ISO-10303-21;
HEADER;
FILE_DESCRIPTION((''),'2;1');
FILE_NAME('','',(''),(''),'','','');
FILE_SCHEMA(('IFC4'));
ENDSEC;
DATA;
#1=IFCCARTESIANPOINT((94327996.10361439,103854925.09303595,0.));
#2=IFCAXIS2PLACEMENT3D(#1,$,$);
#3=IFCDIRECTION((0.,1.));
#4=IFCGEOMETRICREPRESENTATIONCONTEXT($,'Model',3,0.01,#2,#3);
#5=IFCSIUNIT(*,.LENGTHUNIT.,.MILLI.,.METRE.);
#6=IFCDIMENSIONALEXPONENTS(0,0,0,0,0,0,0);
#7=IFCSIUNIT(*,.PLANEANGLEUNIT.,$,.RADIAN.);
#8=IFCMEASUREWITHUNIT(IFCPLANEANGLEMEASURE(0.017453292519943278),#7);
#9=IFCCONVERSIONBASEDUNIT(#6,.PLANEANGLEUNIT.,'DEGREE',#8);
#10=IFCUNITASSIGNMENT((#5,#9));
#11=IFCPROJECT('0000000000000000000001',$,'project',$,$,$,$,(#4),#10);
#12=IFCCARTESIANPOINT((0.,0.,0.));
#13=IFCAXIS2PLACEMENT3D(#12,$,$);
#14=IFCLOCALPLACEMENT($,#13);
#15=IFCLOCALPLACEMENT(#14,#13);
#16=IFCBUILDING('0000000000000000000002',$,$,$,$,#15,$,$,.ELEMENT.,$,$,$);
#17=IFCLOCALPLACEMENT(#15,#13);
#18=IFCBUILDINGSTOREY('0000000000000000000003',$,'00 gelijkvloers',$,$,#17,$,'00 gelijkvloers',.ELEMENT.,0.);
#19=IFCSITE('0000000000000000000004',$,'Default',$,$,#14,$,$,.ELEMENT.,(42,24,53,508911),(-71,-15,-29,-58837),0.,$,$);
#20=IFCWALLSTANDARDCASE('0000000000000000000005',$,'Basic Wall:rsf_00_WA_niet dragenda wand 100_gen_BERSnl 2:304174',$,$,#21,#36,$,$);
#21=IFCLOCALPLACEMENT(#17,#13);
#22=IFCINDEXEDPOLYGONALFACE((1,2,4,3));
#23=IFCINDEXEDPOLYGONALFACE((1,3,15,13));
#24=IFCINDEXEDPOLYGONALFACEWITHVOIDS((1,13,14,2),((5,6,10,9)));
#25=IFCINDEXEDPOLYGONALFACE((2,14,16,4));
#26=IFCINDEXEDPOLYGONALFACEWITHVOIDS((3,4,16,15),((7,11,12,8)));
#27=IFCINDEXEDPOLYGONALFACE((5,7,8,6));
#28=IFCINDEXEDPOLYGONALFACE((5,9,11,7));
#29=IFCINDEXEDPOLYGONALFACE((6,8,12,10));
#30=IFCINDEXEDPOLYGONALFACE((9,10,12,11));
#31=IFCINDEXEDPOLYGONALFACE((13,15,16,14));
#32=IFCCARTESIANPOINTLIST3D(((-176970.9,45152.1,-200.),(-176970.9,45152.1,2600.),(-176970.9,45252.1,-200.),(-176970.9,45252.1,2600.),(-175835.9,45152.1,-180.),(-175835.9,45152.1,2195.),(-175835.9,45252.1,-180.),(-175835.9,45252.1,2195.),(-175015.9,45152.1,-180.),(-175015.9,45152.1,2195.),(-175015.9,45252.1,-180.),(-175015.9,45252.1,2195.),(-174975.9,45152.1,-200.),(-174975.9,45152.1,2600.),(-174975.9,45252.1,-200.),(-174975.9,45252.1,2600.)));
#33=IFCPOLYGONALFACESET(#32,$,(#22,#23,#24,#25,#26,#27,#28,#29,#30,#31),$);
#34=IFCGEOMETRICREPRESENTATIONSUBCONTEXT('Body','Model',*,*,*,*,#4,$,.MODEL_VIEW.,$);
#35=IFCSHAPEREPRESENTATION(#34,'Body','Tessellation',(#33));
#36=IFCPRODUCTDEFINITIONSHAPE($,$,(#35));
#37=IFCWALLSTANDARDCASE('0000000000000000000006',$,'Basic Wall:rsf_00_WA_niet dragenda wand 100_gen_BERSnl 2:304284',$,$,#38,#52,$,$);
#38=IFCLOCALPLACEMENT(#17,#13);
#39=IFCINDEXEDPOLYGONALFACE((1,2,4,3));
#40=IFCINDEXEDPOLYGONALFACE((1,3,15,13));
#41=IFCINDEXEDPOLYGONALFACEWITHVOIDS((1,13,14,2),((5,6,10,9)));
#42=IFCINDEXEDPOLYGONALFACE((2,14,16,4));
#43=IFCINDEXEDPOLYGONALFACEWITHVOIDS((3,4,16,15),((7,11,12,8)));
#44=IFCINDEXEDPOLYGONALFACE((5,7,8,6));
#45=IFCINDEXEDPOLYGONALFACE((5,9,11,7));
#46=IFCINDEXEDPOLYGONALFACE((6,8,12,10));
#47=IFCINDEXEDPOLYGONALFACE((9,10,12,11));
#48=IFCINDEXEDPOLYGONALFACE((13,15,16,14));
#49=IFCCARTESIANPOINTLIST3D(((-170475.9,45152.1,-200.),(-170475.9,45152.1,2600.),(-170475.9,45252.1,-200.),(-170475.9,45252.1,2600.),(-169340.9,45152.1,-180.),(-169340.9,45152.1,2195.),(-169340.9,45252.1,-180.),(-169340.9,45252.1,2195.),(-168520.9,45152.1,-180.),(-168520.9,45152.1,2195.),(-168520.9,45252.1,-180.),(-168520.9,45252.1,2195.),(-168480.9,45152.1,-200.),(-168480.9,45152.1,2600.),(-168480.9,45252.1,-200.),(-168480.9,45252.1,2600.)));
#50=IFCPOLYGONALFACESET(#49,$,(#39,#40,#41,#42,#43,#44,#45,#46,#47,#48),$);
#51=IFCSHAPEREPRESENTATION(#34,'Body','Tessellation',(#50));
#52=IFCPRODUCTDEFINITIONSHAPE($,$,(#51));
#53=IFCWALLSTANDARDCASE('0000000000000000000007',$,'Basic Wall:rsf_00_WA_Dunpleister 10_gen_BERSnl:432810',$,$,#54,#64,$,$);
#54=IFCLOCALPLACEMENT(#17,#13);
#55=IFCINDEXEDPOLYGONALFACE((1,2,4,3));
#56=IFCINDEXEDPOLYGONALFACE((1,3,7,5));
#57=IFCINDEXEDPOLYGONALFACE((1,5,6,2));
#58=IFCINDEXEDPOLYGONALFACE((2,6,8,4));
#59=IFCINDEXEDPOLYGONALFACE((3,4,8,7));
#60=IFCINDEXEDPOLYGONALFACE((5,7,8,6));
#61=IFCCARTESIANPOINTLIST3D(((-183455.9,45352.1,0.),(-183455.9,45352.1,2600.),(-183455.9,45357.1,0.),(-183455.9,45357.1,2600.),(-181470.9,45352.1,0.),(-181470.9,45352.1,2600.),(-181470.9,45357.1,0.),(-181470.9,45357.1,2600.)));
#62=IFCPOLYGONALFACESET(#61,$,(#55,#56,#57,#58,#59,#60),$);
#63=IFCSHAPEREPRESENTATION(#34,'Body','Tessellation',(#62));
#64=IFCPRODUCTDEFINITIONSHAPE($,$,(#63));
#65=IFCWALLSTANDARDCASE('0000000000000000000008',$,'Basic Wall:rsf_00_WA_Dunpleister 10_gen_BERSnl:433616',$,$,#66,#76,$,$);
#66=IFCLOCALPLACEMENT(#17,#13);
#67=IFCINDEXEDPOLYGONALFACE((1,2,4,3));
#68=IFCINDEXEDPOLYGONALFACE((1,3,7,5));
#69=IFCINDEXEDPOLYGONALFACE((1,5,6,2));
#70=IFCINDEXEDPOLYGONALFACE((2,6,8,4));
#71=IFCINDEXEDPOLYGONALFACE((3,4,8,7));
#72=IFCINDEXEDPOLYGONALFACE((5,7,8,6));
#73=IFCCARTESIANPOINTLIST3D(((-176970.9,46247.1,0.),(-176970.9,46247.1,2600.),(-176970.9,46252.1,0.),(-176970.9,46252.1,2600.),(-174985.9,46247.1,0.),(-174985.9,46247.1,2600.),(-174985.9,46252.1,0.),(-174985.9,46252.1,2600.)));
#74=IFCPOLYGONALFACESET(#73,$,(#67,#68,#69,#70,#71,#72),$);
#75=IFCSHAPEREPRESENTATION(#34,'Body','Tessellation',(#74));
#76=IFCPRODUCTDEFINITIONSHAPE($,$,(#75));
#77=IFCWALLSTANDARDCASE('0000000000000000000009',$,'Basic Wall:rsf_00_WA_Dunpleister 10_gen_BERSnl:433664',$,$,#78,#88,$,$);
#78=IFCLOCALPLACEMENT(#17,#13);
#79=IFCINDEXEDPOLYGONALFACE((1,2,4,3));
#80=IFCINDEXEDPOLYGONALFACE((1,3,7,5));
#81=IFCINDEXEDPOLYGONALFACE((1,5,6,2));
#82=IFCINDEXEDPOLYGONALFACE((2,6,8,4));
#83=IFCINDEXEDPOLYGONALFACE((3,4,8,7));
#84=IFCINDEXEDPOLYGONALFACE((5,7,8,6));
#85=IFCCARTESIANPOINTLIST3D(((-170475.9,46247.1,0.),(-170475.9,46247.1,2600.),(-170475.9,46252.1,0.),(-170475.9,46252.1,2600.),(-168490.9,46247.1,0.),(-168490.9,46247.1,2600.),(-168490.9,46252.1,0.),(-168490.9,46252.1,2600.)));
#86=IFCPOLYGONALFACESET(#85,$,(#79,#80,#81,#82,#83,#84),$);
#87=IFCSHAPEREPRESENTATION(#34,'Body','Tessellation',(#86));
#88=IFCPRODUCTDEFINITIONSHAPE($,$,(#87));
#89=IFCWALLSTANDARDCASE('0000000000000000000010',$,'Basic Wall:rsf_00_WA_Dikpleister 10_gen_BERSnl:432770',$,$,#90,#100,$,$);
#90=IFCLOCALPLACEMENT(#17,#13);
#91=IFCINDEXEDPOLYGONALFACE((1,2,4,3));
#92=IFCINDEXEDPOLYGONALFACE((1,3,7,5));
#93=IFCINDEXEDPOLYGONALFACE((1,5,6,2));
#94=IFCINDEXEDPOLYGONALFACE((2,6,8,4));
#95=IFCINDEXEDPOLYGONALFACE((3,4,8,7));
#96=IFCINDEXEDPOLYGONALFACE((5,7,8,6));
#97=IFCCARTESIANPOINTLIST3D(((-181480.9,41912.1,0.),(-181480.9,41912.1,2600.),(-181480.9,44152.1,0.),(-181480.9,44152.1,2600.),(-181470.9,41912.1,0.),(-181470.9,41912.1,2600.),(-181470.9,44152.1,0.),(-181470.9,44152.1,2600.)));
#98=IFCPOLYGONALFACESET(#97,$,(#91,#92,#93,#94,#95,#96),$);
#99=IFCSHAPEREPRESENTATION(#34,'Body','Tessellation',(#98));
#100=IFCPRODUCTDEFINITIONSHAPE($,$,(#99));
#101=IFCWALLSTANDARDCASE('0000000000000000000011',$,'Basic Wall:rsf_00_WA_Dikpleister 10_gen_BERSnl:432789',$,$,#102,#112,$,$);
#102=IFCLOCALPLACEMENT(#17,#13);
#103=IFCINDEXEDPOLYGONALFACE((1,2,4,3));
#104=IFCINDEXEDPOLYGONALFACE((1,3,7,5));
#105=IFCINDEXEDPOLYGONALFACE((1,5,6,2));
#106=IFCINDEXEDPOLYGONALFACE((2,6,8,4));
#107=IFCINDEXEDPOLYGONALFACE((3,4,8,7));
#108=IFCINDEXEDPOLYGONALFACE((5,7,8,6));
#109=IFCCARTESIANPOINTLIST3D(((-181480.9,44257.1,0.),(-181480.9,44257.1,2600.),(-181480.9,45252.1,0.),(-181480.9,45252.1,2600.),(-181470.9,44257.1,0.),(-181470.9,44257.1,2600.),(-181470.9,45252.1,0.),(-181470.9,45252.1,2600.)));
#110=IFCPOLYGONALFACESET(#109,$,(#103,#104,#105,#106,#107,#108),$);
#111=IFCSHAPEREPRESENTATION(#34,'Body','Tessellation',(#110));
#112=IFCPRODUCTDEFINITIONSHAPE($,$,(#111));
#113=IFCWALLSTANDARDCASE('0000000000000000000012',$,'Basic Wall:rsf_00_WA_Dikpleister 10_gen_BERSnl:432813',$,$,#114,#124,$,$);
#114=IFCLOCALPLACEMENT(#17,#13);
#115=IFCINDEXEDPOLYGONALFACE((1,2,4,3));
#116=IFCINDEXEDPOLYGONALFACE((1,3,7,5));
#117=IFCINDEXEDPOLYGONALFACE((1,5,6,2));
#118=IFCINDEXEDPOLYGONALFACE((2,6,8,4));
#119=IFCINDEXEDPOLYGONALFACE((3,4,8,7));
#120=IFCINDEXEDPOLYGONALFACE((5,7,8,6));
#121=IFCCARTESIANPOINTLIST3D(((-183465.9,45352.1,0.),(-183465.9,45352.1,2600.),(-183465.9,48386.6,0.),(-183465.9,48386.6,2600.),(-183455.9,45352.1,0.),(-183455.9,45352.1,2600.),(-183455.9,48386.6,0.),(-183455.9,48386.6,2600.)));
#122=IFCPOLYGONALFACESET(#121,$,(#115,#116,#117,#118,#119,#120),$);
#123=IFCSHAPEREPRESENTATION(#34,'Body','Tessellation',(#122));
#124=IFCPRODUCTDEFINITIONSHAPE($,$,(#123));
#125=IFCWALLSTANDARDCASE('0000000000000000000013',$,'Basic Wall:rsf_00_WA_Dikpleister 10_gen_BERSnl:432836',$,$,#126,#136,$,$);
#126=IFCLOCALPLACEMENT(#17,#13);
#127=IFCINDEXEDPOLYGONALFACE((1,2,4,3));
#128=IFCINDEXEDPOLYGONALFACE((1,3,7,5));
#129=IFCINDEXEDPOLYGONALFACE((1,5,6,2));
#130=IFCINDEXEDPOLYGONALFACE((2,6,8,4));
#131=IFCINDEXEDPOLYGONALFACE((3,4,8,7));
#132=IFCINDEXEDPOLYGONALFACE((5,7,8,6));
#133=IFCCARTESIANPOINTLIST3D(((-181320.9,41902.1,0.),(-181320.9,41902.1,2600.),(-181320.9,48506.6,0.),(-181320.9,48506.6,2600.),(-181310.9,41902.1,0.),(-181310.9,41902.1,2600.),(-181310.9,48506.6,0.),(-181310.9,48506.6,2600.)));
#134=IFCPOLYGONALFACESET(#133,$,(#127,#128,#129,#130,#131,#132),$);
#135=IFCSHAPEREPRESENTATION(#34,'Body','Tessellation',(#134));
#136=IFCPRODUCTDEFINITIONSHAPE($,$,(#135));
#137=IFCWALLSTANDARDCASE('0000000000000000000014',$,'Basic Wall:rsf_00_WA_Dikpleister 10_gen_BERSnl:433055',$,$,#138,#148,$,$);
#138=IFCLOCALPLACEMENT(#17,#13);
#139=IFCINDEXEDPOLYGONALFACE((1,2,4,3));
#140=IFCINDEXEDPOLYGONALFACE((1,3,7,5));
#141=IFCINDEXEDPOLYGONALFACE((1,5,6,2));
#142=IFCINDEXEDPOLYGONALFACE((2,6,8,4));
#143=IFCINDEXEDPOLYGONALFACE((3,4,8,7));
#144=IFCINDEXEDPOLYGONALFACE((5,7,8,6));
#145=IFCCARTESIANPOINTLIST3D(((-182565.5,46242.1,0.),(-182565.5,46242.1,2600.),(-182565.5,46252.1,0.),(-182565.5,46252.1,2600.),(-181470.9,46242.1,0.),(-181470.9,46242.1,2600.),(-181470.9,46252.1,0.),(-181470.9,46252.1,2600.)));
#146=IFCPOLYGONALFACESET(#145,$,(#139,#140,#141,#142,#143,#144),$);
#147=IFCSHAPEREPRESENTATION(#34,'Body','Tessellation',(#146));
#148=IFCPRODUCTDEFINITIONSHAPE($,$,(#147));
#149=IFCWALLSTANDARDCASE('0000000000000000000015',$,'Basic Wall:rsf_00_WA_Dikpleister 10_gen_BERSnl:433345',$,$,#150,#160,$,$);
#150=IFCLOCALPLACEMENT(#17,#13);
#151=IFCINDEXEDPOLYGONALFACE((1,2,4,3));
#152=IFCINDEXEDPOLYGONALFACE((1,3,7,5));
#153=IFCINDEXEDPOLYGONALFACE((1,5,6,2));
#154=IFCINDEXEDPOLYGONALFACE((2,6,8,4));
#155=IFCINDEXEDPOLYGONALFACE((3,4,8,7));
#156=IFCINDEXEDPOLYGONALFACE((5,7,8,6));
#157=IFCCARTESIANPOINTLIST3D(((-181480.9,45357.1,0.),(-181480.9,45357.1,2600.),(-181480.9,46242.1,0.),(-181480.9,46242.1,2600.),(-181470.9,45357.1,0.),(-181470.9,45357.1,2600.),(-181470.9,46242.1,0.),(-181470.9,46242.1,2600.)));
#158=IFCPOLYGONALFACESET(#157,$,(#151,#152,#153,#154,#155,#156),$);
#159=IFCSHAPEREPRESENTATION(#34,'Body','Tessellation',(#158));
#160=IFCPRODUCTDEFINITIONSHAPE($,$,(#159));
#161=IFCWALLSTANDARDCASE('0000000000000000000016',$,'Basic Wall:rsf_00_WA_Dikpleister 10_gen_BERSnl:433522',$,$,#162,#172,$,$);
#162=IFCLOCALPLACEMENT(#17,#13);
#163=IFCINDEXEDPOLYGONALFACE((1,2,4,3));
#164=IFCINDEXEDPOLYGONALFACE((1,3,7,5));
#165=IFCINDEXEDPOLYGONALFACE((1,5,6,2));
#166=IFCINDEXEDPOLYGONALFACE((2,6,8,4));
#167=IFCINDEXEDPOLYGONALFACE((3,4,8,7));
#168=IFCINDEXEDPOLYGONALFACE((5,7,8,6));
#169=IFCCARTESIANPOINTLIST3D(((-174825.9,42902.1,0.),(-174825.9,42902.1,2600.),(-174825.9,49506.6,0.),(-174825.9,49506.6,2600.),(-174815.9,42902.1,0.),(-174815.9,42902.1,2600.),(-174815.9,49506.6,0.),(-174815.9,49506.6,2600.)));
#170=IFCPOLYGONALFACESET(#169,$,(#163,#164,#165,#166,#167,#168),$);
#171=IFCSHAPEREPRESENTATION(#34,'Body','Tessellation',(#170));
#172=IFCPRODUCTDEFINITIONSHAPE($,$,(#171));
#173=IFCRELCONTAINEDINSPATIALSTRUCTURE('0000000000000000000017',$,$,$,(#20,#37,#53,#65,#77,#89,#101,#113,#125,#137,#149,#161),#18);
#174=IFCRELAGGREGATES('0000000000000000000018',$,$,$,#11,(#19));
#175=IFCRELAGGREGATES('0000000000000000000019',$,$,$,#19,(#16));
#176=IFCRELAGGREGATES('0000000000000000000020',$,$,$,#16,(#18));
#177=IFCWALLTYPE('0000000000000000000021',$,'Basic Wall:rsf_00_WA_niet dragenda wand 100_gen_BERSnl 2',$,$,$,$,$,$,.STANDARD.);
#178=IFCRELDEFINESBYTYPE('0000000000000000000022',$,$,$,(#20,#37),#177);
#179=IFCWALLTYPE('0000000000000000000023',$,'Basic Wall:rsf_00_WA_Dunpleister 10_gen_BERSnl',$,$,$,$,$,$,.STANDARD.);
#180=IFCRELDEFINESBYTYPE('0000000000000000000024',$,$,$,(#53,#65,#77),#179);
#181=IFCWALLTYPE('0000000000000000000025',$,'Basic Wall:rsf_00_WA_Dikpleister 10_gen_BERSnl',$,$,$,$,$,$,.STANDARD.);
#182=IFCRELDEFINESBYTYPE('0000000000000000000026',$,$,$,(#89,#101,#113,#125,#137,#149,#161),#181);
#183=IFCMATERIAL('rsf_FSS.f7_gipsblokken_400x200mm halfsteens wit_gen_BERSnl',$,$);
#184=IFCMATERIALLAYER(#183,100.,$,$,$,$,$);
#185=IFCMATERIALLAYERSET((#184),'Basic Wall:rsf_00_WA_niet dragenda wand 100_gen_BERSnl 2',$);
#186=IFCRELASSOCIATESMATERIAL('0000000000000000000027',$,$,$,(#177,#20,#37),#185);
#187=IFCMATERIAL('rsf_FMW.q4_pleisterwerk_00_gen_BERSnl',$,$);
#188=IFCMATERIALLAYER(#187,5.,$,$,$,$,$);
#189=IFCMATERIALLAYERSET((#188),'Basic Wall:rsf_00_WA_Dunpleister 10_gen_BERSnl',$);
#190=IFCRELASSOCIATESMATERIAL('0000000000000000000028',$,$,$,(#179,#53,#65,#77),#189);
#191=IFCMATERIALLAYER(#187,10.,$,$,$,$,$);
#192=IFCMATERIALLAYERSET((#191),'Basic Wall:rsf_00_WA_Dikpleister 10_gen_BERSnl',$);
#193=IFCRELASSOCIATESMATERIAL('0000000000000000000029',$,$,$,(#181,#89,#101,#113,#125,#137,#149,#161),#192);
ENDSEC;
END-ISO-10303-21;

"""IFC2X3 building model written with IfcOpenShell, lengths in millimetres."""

from ifc_helpers import new_model, entity, si_unit, converted_unit, direction, frame, frame_2d, origin, place, context, subcontext, project, spatial, rectangle, extrude, material, layer, layer_set, layer_usage, type_object, element, save


model = new_model("IFC2X3")

# Units and contexts
model_context = context("Model", 3, precision=0.01, world=frame((94327996.10361439, 103854925.09303595, 0.0)), true_north=direction((0.0, 1.0)))
body_context = subcontext(model_context, "Body", "Model", "MODEL_VIEW")
ifc_project = project(units=[si_unit("LENGTHUNIT", "METRE", prefix="MILLI"), converted_unit("PLANEANGLEUNIT", "DEGREE", entity("IfcPlaneAngleMeasure", 0.017453292519943278), si_unit("PLANEANGLEUNIT", "RADIAN"), dimensions=[0, 0, 0, 0, 0, 0, 0])], contexts=[model_context])

# Site, building, storey
site_placement = place(None, origin())
site = spatial("IfcSite", under=ifc_project, at=site_placement, Name="Default", CompositionType="ELEMENT", RefLatitude=(42, 24, 53, 508911), RefLongitude=(-71, -15, -29, -58837), RefElevation=0.0)
building_placement = place(site_placement, origin())
building = spatial("IfcBuilding", under=site, at=building_placement, CompositionType="ELEMENT")
storey_placement = place(building_placement, origin())
storey = spatial("IfcBuildingStorey", under=building, at=storey_placement, Name="00 gelijkvloers", LongName="00 gelijkvloers", CompositionType="ELEMENT", Elevation=0.0)

# Walls, openings
ifc_material_1 = material(Name="rsf_FSS.f7_gipsblokken_400x200mm halfsteens wit_gen_BERSnl")
ifc_layer_1 = layer(ifc_material_1, 100.0)
ifc_layer_set_1 = layer_set([ifc_layer_1], Name="Basic Wall:rsf_00_WA_niet dragenda wand 100_gen_BERSnl 2")
ifc_layer_usage_1 = layer_usage(ifc_layer_set_1, "AXIS2", "NEGATIVE", 50.0)
wall_type_1 = type_object("IfcWallType", Name="Basic Wall:rsf_00_WA_niet dragenda wand 100_gen_BERSnl 2", PredefinedType="STANDARD", material=ifc_layer_set_1)
wall_1_placement = place(storey_placement, frame((-176970.9, 45202.1, -200.0)))
wall_1 = element("IfcWallStandardCase", 1, at=wall_1_placement, inside=storey, type_object=wall_type_1, material=ifc_layer_usage_1, Name="Basic Wall:rsf_00_WA_niet dragenda wand 100_gen_BERSnl 2:304174", context=body_context, shape_type="SweptSolid", body=[
    extrude(rectangle(XDim=1995.0, YDim=100.0, at=frame_2d((997.5, 0.0), x_axis=(-1.0, 0.0))), origin(), (0.0, 0.0, 1.0), 2800.0),
])
opening_1_placement = place(wall_1_placement, frame((1955.0, 50.0, 20.0)))
element("IfcOpeningElement", 2, at=opening_1_placement, cuts=wall_1, ObjectType="Opening", context=body_context, shape_type="SweptSolid", body=[
    extrude(rectangle(XDim=2375.0, YDim=820.0, at=frame_2d((1187.5, 410.0), x_axis=(-1.0, 0.0))), frame((0.0, 0.0, 0.0), z_axis=(0.0, -1.0, 0.0), x_axis=(0.0, 0.0, 1.0)), (0.0, 0.0, 1.0), 100.0),
])
ifc_layer_usage_2 = layer_usage(ifc_layer_set_1, "AXIS2", "NEGATIVE", 50.0)
wall_2_placement = place(storey_placement, frame((-170475.9, 45202.1, -200.0)))
wall_2 = element("IfcWallStandardCase", 3, at=wall_2_placement, inside=storey, type_object=wall_type_1, material=ifc_layer_usage_2, Name="Basic Wall:rsf_00_WA_niet dragenda wand 100_gen_BERSnl 2:304284", context=body_context, shape_type="SweptSolid", body=[
    extrude(rectangle(XDim=1995.0, YDim=100.0, at=frame_2d((997.5, 0.0), x_axis=(-1.0, 0.0))), origin(), (0.0, 0.0, 1.0), 2800.0),
])
opening_2_placement = place(wall_2_placement, frame((1955.0, 50.0, 20.0)))
element("IfcOpeningElement", 4, at=opening_2_placement, cuts=wall_2, ObjectType="Opening", context=body_context, shape_type="SweptSolid", body=[
    extrude(rectangle(XDim=2375.0, YDim=820.0, at=frame_2d((1187.5, 410.0), x_axis=(-1.0, 0.0))), frame((0.0, 0.0, 0.0), z_axis=(0.0, -1.0, 0.0), x_axis=(0.0, 0.0, 1.0)), (0.0, 0.0, 1.0), 100.0),
])
ifc_material_2 = material(Name="rsf_FMW.q4_pleisterwerk_00_gen_BERSnl")
ifc_layer_2 = layer(ifc_material_2, 5.0)
ifc_layer_set_2 = layer_set([ifc_layer_2], Name="Basic Wall:rsf_00_WA_Dunpleister 10_gen_BERSnl")
wall_type_2 = type_object("IfcWallType", Name="Basic Wall:rsf_00_WA_Dunpleister 10_gen_BERSnl", PredefinedType="STANDARD", material=ifc_layer_set_2)

# Wall
ifc_layer_usage_3 = layer_usage(ifc_layer_set_2, "AXIS2", "POSITIVE", -2.5)
wall_3_placement = place(storey_placement, frame((-181470.9, 45354.6, 0.0), z_axis=(0.0, 0.0, 1.0), x_axis=(-1.0, 0.0, 0.0)))
element("IfcWallStandardCase", 5, at=wall_3_placement, inside=storey, type_object=wall_type_2, material=ifc_layer_usage_3, Name="Basic Wall:rsf_00_WA_Dunpleister 10_gen_BERSnl:432810", context=body_context, shape_type="SweptSolid", body=[
    extrude(rectangle(XDim=1985.0, YDim=5.0, at=frame_2d((992.5, 0.0), x_axis=(-1.0, 0.0))), origin(), (0.0, 0.0, 1.0), 2600.0),
])

# Wall
ifc_layer_usage_4 = layer_usage(ifc_layer_set_2, "AXIS2", "POSITIVE", -2.5)
wall_4_placement = place(storey_placement, frame((-176970.9, 46249.6, 0.0)))
element("IfcWallStandardCase", 6, at=wall_4_placement, inside=storey, type_object=wall_type_2, material=ifc_layer_usage_4, Name="Basic Wall:rsf_00_WA_Dunpleister 10_gen_BERSnl:433616", context=body_context, shape_type="SweptSolid", body=[
    extrude(rectangle(XDim=1985.0, YDim=5.0, at=frame_2d((992.5, 0.0), x_axis=(-1.0, 0.0))), origin(), (0.0, 0.0, 1.0), 2600.0),
])

# Walls
ifc_layer_usage_5 = layer_usage(ifc_layer_set_2, "AXIS2", "POSITIVE", -2.5)
wall_5_placement = place(storey_placement, frame((-170475.9, 46249.6, 0.0)))
element("IfcWallStandardCase", 7, at=wall_5_placement, inside=storey, type_object=wall_type_2, material=ifc_layer_usage_5, Name="Basic Wall:rsf_00_WA_Dunpleister 10_gen_BERSnl:433664", context=body_context, shape_type="SweptSolid", body=[
    extrude(rectangle(XDim=1985.0, YDim=5.0, at=frame_2d((992.5, 0.0), x_axis=(-1.0, 0.0))), origin(), (0.0, 0.0, 1.0), 2600.0),
])
ifc_layer_3 = layer(ifc_material_2, 10.0)
ifc_layer_set_3 = layer_set([ifc_layer_3], Name="Basic Wall:rsf_00_WA_Dikpleister 10_gen_BERSnl")
ifc_layer_usage_6 = layer_usage(ifc_layer_set_3, "AXIS2", "POSITIVE", -5.0)
wall_type_3 = type_object("IfcWallType", Name="Basic Wall:rsf_00_WA_Dikpleister 10_gen_BERSnl", PredefinedType="STANDARD", material=ifc_layer_set_3)
wall_6_placement = place(storey_placement, frame((-181475.9, 44152.1, 0.0), z_axis=(0.0, 0.0, 1.0), x_axis=(0.0, -1.0, 0.0)))
element("IfcWallStandardCase", 8, at=wall_6_placement, inside=storey, type_object=wall_type_3, material=ifc_layer_usage_6, Name="Basic Wall:rsf_00_WA_Dikpleister 10_gen_BERSnl:432770", context=body_context, shape_type="SweptSolid", body=[
    extrude(rectangle(XDim=2240.0, YDim=10.0, at=frame_2d((1120.0, 0.0), x_axis=(-1.0, 0.0))), origin(), (0.0, 0.0, 1.0), 2600.0),
])
ifc_layer_usage_7 = layer_usage(ifc_layer_set_3, "AXIS2", "POSITIVE", -5.0)
wall_7_placement = place(storey_placement, frame((-181475.9, 45252.1, 0.0), z_axis=(0.0, 0.0, 1.0), x_axis=(0.0, -1.0, 0.0)))
element("IfcWallStandardCase", 9, at=wall_7_placement, inside=storey, type_object=wall_type_3, material=ifc_layer_usage_7, Name="Basic Wall:rsf_00_WA_Dikpleister 10_gen_BERSnl:432789", context=body_context, shape_type="SweptSolid", body=[
    extrude(rectangle(XDim=995.0, YDim=10.0, at=frame_2d((497.5, 0.0), x_axis=(-1.0, 0.0))), origin(), (0.0, 0.0, 1.0), 2600.0),
])
ifc_layer_usage_8 = layer_usage(ifc_layer_set_3, "AXIS2", "POSITIVE", -5.0)
wall_8_placement = place(storey_placement, frame((-183460.9, 45352.1, 0.0), z_axis=(0.0, 0.0, 1.0), x_axis=(0.0, 1.0, 0.0)))
element("IfcWallStandardCase", 10, at=wall_8_placement, inside=storey, type_object=wall_type_3, material=ifc_layer_usage_8, Name="Basic Wall:rsf_00_WA_Dikpleister 10_gen_BERSnl:432813", context=body_context, shape_type="SweptSolid", body=[
    extrude(rectangle(XDim=3034.5, YDim=10.0, at=frame_2d((1517.3, 0.0), x_axis=(-1.0, 0.0))), origin(), (0.0, 0.0, 1.0), 2600.0),
])
ifc_layer_usage_9 = layer_usage(ifc_layer_set_3, "AXIS2", "POSITIVE", -5.0)
wall_9_placement = place(storey_placement, frame((-181315.9, 41902.1, 0.0), z_axis=(0.0, 0.0, 1.0), x_axis=(0.0, 1.0, 0.0)))
element("IfcWallStandardCase", 11, at=wall_9_placement, inside=storey, type_object=wall_type_3, material=ifc_layer_usage_9, Name="Basic Wall:rsf_00_WA_Dikpleister 10_gen_BERSnl:432836", context=body_context, shape_type="SweptSolid", body=[
    extrude(rectangle(XDim=6604.5, YDim=10.0, at=frame_2d((3302.3, 0.0), x_axis=(-1.0, 0.0))), origin(), (0.0, 0.0, 1.0), 2600.0),
])
ifc_layer_usage_10 = layer_usage(ifc_layer_set_3, "AXIS2", "POSITIVE", -5.0)
wall_10_placement = place(storey_placement, frame((-182565.5, 46247.1, 0.0)))
element("IfcWallStandardCase", 12, at=wall_10_placement, inside=storey, type_object=wall_type_3, material=ifc_layer_usage_10, Name="Basic Wall:rsf_00_WA_Dikpleister 10_gen_BERSnl:433055", context=body_context, shape_type="SweptSolid", body=[
    extrude(rectangle(XDim=1094.6, YDim=10.0, at=frame_2d((547.3, 0.0), x_axis=(-1.0, 0.0))), origin(), (0.0, 0.0, 1.0), 2600.0),
])
ifc_layer_usage_11 = layer_usage(ifc_layer_set_3, "AXIS2", "POSITIVE", -5.0)
wall_11_placement = place(storey_placement, frame((-181475.9, 46242.1, 0.0), z_axis=(0.0, 0.0, 1.0), x_axis=(0.0, -1.0, 0.0)))
element("IfcWallStandardCase", 13, at=wall_11_placement, inside=storey, type_object=wall_type_3, material=ifc_layer_usage_11, Name="Basic Wall:rsf_00_WA_Dikpleister 10_gen_BERSnl:433345", context=body_context, shape_type="SweptSolid", body=[
    extrude(rectangle(XDim=885.0, YDim=10.0, at=frame_2d((442.5, 0.0), x_axis=(-1.0, 0.0))), origin(), (0.0, 0.0, 1.0), 2600.0),
])
ifc_layer_usage_12 = layer_usage(ifc_layer_set_3, "AXIS2", "POSITIVE", -5.0)
wall_12_placement = place(storey_placement, frame((-174820.9, 42902.1, 0.0), z_axis=(0.0, 0.0, 1.0), x_axis=(0.0, 1.0, 0.0)))
element("IfcWallStandardCase", 14, at=wall_12_placement, inside=storey, type_object=wall_type_3, material=ifc_layer_usage_12, Name="Basic Wall:rsf_00_WA_Dikpleister 10_gen_BERSnl:433522", context=body_context, shape_type="SweptSolid", body=[
    extrude(rectangle(XDim=6604.5, YDim=10.0, at=frame_2d((3302.3, 0.0), x_axis=(-1.0, 0.0))), origin(), (0.0, 0.0, 1.0), 2600.0),
])

save(model, "model.ifc")
